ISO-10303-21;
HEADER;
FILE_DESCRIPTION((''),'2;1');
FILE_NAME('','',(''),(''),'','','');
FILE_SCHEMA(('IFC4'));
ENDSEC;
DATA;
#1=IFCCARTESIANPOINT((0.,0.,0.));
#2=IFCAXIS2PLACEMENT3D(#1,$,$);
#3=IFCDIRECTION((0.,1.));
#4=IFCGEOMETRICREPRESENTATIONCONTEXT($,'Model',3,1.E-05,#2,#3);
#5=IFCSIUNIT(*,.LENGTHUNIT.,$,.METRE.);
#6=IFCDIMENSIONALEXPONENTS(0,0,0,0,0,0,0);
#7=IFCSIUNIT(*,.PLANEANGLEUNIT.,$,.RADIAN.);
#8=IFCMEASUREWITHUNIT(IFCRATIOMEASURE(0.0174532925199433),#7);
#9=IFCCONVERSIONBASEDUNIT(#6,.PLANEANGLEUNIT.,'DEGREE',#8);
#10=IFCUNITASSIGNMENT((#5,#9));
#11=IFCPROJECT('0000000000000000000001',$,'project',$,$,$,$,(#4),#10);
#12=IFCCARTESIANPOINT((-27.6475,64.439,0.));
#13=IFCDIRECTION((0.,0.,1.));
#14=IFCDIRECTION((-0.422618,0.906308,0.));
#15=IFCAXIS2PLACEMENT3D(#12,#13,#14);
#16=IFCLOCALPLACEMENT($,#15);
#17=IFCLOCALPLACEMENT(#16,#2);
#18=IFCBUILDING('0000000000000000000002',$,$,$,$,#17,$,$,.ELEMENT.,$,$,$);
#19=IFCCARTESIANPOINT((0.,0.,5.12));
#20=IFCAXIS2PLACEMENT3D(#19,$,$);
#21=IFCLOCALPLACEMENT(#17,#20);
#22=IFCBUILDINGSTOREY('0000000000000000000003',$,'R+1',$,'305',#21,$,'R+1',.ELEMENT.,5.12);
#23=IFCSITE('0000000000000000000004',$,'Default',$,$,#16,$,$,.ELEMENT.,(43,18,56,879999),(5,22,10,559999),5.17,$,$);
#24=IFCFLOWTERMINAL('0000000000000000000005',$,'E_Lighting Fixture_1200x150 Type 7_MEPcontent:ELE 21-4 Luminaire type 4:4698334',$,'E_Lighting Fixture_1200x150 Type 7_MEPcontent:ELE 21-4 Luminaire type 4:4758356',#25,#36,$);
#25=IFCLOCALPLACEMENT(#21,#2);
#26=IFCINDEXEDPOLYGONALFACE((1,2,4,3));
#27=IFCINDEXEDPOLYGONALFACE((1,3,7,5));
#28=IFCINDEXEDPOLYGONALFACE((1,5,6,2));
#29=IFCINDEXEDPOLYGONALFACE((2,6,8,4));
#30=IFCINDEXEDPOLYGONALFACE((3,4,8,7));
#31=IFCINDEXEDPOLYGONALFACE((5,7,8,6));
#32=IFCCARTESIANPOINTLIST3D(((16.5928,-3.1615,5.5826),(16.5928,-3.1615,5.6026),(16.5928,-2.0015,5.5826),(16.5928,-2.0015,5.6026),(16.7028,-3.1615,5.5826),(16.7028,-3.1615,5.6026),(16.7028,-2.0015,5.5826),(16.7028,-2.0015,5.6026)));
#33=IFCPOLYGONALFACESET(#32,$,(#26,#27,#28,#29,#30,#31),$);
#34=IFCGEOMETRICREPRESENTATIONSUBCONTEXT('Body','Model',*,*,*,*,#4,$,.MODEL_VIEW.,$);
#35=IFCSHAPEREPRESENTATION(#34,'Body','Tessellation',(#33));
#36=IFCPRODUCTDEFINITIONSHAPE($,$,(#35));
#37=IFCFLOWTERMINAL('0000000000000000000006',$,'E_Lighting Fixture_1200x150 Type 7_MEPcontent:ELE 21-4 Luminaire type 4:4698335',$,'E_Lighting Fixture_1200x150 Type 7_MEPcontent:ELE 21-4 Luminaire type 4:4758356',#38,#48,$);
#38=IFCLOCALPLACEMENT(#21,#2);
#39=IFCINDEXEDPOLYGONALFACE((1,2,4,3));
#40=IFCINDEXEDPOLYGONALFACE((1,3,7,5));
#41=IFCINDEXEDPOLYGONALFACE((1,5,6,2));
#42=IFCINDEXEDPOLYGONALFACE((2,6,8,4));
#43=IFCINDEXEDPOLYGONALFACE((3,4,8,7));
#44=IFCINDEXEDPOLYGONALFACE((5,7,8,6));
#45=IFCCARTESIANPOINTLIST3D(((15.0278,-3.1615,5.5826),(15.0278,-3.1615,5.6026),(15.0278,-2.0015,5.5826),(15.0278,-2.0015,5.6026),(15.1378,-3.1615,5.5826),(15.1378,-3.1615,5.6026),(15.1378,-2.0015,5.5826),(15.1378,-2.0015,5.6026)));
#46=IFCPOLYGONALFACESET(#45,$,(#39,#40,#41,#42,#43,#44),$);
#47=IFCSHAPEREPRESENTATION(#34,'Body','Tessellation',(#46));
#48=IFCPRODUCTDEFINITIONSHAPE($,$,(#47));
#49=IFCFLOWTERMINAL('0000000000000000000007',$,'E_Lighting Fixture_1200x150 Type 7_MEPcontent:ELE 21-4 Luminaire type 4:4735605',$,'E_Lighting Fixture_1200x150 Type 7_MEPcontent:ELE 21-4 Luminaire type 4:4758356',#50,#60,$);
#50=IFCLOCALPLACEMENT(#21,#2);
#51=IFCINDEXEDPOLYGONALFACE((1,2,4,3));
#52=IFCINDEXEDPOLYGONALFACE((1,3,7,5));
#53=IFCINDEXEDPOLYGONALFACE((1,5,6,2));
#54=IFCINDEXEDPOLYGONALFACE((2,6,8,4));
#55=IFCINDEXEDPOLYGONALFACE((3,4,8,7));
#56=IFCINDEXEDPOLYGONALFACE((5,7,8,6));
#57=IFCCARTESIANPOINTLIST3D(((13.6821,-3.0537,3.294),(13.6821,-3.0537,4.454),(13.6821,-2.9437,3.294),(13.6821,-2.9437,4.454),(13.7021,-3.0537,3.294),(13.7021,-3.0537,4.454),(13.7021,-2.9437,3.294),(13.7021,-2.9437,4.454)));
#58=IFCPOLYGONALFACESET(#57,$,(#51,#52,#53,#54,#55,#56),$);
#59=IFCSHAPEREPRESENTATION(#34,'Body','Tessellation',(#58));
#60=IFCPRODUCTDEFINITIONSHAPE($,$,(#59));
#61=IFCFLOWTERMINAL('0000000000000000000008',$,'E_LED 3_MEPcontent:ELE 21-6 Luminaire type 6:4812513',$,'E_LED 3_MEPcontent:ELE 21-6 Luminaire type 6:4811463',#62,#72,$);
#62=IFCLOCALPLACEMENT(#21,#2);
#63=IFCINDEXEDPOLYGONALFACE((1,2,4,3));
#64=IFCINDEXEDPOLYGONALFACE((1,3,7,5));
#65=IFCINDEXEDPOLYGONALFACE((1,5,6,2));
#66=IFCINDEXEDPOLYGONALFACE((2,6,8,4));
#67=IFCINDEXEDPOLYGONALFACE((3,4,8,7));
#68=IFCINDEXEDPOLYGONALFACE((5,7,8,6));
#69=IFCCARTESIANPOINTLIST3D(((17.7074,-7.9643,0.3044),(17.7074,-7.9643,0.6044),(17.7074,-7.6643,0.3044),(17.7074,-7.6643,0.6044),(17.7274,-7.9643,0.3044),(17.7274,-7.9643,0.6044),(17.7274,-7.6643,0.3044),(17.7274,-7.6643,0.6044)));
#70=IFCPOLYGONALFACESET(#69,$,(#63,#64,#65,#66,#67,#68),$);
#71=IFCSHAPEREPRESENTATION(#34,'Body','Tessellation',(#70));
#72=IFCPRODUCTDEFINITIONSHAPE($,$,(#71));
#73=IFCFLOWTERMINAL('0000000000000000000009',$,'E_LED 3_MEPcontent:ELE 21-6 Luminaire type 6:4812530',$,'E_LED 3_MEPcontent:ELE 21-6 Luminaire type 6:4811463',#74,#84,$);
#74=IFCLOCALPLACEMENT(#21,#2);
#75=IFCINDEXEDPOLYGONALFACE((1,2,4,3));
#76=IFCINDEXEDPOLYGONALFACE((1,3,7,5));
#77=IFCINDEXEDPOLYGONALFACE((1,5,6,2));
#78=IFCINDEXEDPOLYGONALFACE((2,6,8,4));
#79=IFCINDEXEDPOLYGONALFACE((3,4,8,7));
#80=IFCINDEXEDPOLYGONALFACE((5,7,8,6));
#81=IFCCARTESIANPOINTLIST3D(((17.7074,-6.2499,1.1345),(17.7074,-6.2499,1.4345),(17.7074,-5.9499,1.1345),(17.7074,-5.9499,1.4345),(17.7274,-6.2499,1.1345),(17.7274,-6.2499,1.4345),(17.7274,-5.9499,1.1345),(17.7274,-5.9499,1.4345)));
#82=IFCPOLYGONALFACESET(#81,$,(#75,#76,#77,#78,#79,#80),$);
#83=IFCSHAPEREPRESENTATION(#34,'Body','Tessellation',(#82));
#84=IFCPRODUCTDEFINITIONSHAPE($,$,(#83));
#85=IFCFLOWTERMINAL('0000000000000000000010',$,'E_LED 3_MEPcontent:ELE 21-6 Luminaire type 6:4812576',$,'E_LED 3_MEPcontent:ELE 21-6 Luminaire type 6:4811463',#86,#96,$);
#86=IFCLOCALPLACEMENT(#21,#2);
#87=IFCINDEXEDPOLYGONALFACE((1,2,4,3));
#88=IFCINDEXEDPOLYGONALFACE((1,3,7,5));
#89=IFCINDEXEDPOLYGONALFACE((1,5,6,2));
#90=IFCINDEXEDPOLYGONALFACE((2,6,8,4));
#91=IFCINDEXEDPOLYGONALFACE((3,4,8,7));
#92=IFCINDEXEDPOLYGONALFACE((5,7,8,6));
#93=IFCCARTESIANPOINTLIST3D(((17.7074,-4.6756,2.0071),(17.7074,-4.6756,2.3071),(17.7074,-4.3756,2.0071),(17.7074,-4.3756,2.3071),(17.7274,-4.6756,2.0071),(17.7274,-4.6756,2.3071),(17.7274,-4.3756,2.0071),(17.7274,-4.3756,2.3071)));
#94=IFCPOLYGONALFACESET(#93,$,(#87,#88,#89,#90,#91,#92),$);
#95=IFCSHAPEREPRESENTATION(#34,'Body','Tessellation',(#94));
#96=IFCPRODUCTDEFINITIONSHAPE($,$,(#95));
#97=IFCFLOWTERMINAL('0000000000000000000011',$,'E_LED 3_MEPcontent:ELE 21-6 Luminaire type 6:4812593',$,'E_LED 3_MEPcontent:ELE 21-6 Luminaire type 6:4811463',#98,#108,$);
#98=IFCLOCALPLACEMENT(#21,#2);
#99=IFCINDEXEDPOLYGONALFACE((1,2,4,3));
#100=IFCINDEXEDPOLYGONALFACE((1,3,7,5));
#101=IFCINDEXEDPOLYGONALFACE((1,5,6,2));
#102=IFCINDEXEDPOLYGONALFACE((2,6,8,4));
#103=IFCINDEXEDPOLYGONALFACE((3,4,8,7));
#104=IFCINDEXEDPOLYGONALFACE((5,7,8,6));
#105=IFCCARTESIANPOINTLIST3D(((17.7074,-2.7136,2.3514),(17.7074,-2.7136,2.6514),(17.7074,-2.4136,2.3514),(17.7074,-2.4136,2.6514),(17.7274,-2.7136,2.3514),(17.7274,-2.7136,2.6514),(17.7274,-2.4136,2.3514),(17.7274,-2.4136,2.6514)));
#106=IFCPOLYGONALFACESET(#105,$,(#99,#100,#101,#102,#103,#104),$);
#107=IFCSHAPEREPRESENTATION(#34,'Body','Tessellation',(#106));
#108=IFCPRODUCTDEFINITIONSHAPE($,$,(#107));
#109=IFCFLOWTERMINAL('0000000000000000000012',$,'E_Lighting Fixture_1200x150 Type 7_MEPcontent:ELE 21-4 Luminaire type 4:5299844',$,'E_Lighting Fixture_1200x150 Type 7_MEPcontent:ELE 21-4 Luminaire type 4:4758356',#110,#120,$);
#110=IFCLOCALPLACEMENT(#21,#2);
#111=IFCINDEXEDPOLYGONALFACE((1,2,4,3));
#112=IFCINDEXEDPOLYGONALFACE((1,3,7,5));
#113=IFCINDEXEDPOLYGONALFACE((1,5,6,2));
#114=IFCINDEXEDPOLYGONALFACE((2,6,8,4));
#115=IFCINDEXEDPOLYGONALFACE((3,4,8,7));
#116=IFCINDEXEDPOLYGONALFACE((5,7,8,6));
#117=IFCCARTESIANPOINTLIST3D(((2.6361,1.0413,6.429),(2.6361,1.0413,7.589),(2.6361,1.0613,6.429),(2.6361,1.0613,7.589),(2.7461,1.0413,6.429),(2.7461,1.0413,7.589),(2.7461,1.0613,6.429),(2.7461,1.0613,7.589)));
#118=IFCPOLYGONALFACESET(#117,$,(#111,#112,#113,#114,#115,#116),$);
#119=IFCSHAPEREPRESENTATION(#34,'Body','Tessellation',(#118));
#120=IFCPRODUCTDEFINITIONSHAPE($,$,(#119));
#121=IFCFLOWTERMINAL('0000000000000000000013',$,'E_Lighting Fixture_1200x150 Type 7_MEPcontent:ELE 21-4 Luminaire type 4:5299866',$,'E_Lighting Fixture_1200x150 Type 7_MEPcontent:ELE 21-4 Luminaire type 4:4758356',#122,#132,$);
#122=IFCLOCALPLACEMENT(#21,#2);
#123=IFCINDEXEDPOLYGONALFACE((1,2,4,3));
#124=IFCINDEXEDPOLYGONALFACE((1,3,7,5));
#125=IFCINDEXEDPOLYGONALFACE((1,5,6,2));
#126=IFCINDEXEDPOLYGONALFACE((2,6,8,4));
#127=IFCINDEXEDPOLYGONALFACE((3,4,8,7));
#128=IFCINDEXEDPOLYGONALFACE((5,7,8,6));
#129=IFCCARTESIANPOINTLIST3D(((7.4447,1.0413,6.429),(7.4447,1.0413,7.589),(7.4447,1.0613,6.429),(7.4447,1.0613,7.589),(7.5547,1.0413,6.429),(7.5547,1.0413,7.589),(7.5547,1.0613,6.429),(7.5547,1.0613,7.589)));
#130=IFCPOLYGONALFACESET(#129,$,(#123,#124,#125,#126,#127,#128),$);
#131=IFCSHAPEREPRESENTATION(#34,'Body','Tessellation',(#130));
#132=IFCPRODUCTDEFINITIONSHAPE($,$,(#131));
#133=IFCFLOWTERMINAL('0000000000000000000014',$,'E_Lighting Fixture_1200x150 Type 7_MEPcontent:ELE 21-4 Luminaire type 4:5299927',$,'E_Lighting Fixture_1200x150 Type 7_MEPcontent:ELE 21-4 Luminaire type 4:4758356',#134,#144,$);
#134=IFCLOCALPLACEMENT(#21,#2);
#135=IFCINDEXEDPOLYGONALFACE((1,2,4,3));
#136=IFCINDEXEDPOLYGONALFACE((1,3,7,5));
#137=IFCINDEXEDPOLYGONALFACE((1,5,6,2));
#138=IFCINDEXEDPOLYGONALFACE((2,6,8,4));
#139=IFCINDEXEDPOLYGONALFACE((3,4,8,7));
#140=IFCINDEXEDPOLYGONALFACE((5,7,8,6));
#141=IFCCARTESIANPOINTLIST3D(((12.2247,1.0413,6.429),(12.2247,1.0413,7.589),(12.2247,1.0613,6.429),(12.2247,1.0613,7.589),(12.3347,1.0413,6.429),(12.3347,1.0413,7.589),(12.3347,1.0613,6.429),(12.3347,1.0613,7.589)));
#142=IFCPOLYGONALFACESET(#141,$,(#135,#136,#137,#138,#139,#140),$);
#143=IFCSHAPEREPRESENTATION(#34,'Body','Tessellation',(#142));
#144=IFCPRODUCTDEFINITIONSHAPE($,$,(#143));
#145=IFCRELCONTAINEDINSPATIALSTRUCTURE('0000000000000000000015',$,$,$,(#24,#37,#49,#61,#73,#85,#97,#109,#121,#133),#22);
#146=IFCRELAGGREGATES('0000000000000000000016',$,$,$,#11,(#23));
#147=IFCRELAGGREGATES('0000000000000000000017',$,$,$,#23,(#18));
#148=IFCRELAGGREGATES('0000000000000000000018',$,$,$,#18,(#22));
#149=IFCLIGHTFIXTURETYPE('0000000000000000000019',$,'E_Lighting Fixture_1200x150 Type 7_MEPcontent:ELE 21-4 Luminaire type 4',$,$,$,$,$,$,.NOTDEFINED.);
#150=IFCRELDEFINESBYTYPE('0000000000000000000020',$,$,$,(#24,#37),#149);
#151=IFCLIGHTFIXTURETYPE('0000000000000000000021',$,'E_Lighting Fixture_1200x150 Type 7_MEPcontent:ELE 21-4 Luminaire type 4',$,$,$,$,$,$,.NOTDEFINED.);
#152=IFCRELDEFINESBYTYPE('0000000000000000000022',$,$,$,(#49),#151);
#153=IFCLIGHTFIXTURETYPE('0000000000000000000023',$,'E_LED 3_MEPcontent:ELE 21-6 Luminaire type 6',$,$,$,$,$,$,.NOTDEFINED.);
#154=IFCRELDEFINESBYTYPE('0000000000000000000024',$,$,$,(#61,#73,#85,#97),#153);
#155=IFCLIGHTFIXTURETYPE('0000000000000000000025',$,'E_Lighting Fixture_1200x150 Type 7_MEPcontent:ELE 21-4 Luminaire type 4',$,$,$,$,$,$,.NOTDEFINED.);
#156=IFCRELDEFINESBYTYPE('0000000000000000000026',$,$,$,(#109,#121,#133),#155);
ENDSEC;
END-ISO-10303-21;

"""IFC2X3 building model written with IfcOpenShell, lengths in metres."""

from ifc_helpers import new_model, entity, si_unit, converted_unit, direction, frame, frame_2d, origin, origin_2d_with_axis, place, context, subcontext, project, spatial, rectangle, extrude, source, transform, mapped, type_object, type_shapes, element, save


model = new_model("IFC2X3")

# Units and contexts
model_context = context("Model", 3, precision=1e-05, world=origin(), true_north=direction((0.0, 1.0)))
body_context = subcontext(model_context, "Body", "Model", "MODEL_VIEW")
ifc_project = project(units=[si_unit("LENGTHUNIT", "METRE"), converted_unit("PLANEANGLEUNIT", "DEGREE", entity("IfcRatioMeasure", 0.0174532925199433), si_unit("PLANEANGLEUNIT", "RADIAN"), dimensions=[0, 0, 0, 0, 0, 0, 0])], contexts=[model_context])

# Site, building, storey
site_placement = place(None, frame((-27.6475, 64.439, 0.0), z_axis=(0.0, 0.0, 1.0), x_axis=(-0.422618, 0.906308, 0.0)))
site = spatial("IfcSite", under=ifc_project, at=site_placement, Name="Default", CompositionType="ELEMENT", RefLatitude=(43, 18, 56, 879999), RefLongitude=(5, 22, 10, 559999), RefElevation=5.17)
building_placement = place(site_placement, origin())
building = spatial("IfcBuilding", under=site, at=building_placement, CompositionType="ELEMENT")
storey_placement = place(building_placement, frame((0.0, 0.0, 5.12)))
storey = spatial("IfcBuildingStorey", under=building, at=storey_placement, Name="R+1", ObjectType="305", LongName="R+1", CompositionType="ELEMENT", Elevation=5.12)

# Flow terminals
light_fixture_type_1 = type_object("IfcLightFixtureType", Name="E_Lighting Fixture_1200x150 Type 7_MEPcontent:ELE 21-4 Luminaire type 4", PredefinedType="NOTDEFINED")
shared_shape_1 = source(origin(), body_context, "Body", "SweptSolid", [
    extrude(rectangle(XDim=1.16, YDim=0.11, at=origin_2d_with_axis()), frame((0.0, 0.0, -0.02)), (0.0, 0.0, 1.0), 0.02),
])
type_shapes(light_fixture_type_1, [shared_shape_1])
for number, where, z_axis, x_axis, name in (
    (1, (16.6478, -2.5815, 5.6026), (0.0, 0.0, 1.0), (0.0, -1.0, 0.0), "E_Lighting Fixture_1200x150 Type 7_MEPcontent:ELE 21-4 Luminaire type 4:4698334"),
    (2, (15.0828, -2.5815, 5.6026), (0.0, 0.0, 1.0), (0.0, -1.0, 0.0), "E_Lighting Fixture_1200x150 Type 7_MEPcontent:ELE 21-4 Luminaire type 4:4698335"),
):
    element("IfcFlowTerminal", number, at=place(storey_placement, frame(where, z_axis=z_axis, x_axis=x_axis)), inside=storey, type_object=light_fixture_type_1, Name=name, ObjectType="E_Lighting Fixture_1200x150 Type 7_MEPcontent:ELE 21-4 Luminaire type 4:4758356", context=body_context, shape_type="MappedRepresentation", body=[
        mapped(shared_shape_1, transform((0.0, 0.0, 0.0), scale=1.0)),
    ])
light_fixture_type_2 = type_object("IfcLightFixtureType", Name="E_Lighting Fixture_1200x150 Type 7_MEPcontent:ELE 21-4 Luminaire type 4", PredefinedType="NOTDEFINED")
shared_shape_2 = source(origin(), body_context, "Body", "SweptSolid", [
    extrude(rectangle(XDim=0.02, YDim=0.11, at=frame_2d((0.0, 0.0), x_axis=(1.0, 0.0))), frame((0.0, 0.01, -0.58), z_axis=(0.0, 0.0, 1.0), x_axis=(0.0, -1.0, 0.0)), (0.0, 0.0, 1.0), 1.16),
])
type_shapes(light_fixture_type_2, [shared_shape_2])
flow_terminal_placement = place(storey_placement, frame((13.6821, -2.9987, 3.874), z_axis=(0.0, 0.0, 1.0), x_axis=(0.0, -1.0, 0.0)))
element("IfcFlowTerminal", 3, at=flow_terminal_placement, inside=storey, type_object=light_fixture_type_2, Name="E_Lighting Fixture_1200x150 Type 7_MEPcontent:ELE 21-4 Luminaire type 4:4735605", ObjectType="E_Lighting Fixture_1200x150 Type 7_MEPcontent:ELE 21-4 Luminaire type 4:4758356", context=body_context, shape_type="MappedRepresentation", body=[
    mapped(shared_shape_2, transform((0.0, 0.0, 0.0), scale=1.0)),
])
light_fixture_type_3 = type_object("IfcLightFixtureType", Name="E_LED 3_MEPcontent:ELE 21-6 Luminaire type 6", PredefinedType="NOTDEFINED")
shared_shape_3 = source(origin(), body_context, "Body", "SweptSolid", [
    extrude(rectangle(XDim=0.02, YDim=0.3, at=origin_2d_with_axis()), frame((0.0, 0.01, -0.15), z_axis=(0.0, 0.0, 1.0), x_axis=(0.0, -1.0, 0.0)), (0.0, 0.0, 1.0), 0.3),
])
type_shapes(light_fixture_type_3, [shared_shape_3])
for number, where, z_axis, x_axis, name in (
    (4, (17.7074, -7.8143, 0.4544), (0.0, 0.0, 1.0), (0.0, -1.0, 0.0), "E_LED 3_MEPcontent:ELE 21-6 Luminaire type 6:4812513"),
    (5, (17.7074, -6.0999, 1.2845), (0.0, 0.0, 1.0), (0.0, -1.0, 0.0), "E_LED 3_MEPcontent:ELE 21-6 Luminaire type 6:4812530"),
    (6, (17.7074, -4.5256, 2.1571), (0.0, 0.0, 1.0), (0.0, -1.0, 0.0), "E_LED 3_MEPcontent:ELE 21-6 Luminaire type 6:4812576"),
    (7, (17.7074, -2.5636, 2.5014), (0.0, 0.0, 1.0), (0.0, -1.0, 0.0), "E_LED 3_MEPcontent:ELE 21-6 Luminaire type 6:4812593"),
):
    element("IfcFlowTerminal", number, at=place(storey_placement, frame(where, z_axis=z_axis, x_axis=x_axis)), inside=storey, type_object=light_fixture_type_3, Name=name, ObjectType="E_LED 3_MEPcontent:ELE 21-6 Luminaire type 6:4811463", context=body_context, shape_type="MappedRepresentation", body=[
        mapped(shared_shape_3, transform((0.0, 0.0, 0.0), scale=1.0)),
    ])
light_fixture_type_4 = type_object("IfcLightFixtureType", Name="E_Lighting Fixture_1200x150 Type 7_MEPcontent:ELE 21-4 Luminaire type 4", PredefinedType="NOTDEFINED")
shared_shape_4 = source(origin(), body_context, "Body", "SweptSolid", [
    extrude(rectangle(XDim=0.02, YDim=0.11, at=frame_2d((0.0, 0.0), x_axis=(1.0, 0.0))), frame((0.01, 0.0, -0.58), z_axis=(0.0, 0.0, 1.0), x_axis=(-1.0, 0.0, 0.0)), (0.0, 0.0, 1.0), 1.16),
])
type_shapes(light_fixture_type_4, [shared_shape_4])
for number, where, z_axis, x_axis, name in (
    (8, (2.6911, 1.0413, 7.009), (0.0, 0.0, 1.0), (0.0, 1.0, 0.0), "E_Lighting Fixture_1200x150 Type 7_MEPcontent:ELE 21-4 Luminaire type 4:5299844"),
    (9, (7.4997, 1.0413, 7.009), (0.0, 0.0, 1.0), (0.0, 1.0, 0.0), "E_Lighting Fixture_1200x150 Type 7_MEPcontent:ELE 21-4 Luminaire type 4:5299866"),
    (10, (12.2797, 1.0413, 7.009), (0.0, 0.0, 1.0), (0.0, 1.0, 0.0), "E_Lighting Fixture_1200x150 Type 7_MEPcontent:ELE 21-4 Luminaire type 4:5299927"),
):
    element("IfcFlowTerminal", number, at=place(storey_placement, frame(where, z_axis=z_axis, x_axis=x_axis)), inside=storey, type_object=light_fixture_type_4, Name=name, ObjectType="E_Lighting Fixture_1200x150 Type 7_MEPcontent:ELE 21-4 Luminaire type 4:4758356", context=body_context, shape_type="MappedRepresentation", body=[
        mapped(shared_shape_4, transform((0.0, 0.0, 0.0), scale=1.0)),
    ])

save(model, "model.ifc")
